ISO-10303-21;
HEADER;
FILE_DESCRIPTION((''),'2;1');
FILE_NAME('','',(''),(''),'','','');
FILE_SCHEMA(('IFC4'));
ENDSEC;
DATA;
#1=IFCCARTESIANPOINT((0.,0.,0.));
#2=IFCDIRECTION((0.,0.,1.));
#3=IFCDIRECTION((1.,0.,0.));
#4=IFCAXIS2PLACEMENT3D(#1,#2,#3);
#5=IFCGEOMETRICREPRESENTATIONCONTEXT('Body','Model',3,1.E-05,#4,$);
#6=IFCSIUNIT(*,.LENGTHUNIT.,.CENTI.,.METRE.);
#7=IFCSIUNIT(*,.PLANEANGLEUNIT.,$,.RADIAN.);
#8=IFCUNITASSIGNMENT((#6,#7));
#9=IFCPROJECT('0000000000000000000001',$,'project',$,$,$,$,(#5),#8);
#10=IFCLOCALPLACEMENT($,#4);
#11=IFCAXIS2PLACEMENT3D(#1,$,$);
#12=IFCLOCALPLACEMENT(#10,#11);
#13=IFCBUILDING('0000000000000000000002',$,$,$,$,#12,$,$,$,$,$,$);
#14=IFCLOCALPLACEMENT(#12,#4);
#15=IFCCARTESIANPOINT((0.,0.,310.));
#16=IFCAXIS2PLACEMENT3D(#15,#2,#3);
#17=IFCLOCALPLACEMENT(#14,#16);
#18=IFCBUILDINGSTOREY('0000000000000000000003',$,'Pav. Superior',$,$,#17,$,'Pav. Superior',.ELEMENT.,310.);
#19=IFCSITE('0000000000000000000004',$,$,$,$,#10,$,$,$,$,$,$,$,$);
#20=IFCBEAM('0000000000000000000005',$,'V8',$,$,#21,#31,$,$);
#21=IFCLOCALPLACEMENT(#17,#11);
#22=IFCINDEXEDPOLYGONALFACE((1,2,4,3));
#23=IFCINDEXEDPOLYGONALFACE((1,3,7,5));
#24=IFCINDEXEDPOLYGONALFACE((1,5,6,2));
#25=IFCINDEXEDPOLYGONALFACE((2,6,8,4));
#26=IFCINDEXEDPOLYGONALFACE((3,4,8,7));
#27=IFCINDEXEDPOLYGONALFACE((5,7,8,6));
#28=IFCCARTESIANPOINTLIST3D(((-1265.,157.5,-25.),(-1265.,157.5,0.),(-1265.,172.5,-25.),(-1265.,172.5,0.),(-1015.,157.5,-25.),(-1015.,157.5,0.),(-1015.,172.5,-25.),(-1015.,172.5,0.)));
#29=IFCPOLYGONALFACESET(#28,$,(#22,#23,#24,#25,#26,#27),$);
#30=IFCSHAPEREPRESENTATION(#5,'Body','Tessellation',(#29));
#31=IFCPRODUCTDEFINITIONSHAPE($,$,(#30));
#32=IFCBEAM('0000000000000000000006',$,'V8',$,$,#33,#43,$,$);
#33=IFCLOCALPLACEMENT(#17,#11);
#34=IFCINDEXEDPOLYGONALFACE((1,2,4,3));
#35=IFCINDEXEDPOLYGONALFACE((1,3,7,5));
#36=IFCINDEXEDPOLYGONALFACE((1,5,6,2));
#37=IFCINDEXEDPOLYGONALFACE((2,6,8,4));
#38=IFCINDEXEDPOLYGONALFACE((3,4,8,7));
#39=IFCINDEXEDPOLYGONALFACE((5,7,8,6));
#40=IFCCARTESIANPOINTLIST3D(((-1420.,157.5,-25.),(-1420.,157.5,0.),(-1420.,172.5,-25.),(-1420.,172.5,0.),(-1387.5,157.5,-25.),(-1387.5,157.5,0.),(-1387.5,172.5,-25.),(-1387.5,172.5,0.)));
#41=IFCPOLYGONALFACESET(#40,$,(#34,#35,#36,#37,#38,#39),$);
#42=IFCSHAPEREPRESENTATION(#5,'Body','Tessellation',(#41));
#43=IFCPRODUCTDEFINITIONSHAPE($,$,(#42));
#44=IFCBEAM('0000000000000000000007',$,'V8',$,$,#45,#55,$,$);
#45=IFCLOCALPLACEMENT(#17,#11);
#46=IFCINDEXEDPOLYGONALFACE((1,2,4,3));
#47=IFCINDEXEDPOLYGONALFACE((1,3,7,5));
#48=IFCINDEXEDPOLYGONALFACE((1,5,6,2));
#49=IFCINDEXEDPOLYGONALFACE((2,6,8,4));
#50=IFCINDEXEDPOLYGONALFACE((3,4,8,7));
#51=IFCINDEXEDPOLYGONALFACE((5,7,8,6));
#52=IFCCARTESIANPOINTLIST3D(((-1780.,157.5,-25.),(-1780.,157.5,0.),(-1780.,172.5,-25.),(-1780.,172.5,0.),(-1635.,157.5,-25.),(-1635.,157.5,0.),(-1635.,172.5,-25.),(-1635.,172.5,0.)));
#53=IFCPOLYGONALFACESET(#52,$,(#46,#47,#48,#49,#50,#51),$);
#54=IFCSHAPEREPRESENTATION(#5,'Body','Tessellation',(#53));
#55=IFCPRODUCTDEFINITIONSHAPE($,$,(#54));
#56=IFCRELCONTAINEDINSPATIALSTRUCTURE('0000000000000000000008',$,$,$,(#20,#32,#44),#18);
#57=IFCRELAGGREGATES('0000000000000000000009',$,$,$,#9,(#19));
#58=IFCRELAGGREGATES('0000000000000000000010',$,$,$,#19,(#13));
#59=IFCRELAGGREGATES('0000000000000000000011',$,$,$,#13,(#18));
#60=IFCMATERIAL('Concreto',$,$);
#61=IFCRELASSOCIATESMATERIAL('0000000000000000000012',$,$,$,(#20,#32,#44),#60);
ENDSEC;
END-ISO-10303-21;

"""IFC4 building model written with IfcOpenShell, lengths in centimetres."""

from ifc_helpers import new_model, si_unit, frame, origin, origin_with_axes, origin_2d_with_axis, place, context, project, spatial, rectangle, extrude, material, element, save


model = new_model("IFC4")

# Units and contexts
model_context = context("Model", 3, precision=1e-05, world=origin_with_axes(), identifier="Body")
ifc_project = project(units=[si_unit("LENGTHUNIT", "METRE", prefix="CENTI"), si_unit("PLANEANGLEUNIT", "RADIAN")], contexts=[model_context])

# Site, building, storey
site_placement = place(None, origin_with_axes())
site = spatial("IfcSite", under=ifc_project, at=site_placement)
building_placement = place(site_placement, origin())
building = spatial("IfcBuilding", under=site, at=building_placement)
placement = place(building_placement, origin_with_axes())
storey_placement = place(placement, frame((0.0, 0.0, 310.0), z_axis=(0.0, 0.0, 1.0), x_axis=(1.0, 0.0, 0.0)))
storey = spatial("IfcBuildingStorey", under=building, at=storey_placement, Name="Pav. Superior", LongName="Pav. Superior", CompositionType="ELEMENT", Elevation=310.0)

# Shared definitions
ifc_material = material(Name="Concreto")

# Beams
beam_1_placement = place(storey_placement, frame((-1140.0, 165.0, 0.0), z_axis=(0.0, 0.0, 1.0), x_axis=(1.0, 0.0, 0.0)))
element("IfcBeam", 1, at=beam_1_placement, inside=storey, material=ifc_material, Name="V8", context=model_context, shape_type="SolidModel", body=[
    extrude(rectangle(XDim=15.0, YDim=25.0, at=origin_2d_with_axis()), frame((-125.0, 0.0, -12.5), z_axis=(1.0, 0.0, 0.0), x_axis=(0.0, -1.0, 0.0)), (0.0, 0.0, 1.0), 250.0),
])
beam_2_placement = place(storey_placement, frame((-1403.75, 165.0, 0.0), z_axis=(0.0, 0.0, 1.0), x_axis=(1.0, 0.0, 0.0)))
element("IfcBeam", 2, at=beam_2_placement, inside=storey, material=ifc_material, Name="V8", context=model_context, shape_type="SolidModel", body=[
    extrude(rectangle(XDim=15.0, YDim=25.0, at=origin_2d_with_axis()), frame((-16.25, 0.0, -12.5), z_axis=(1.0, 0.0, 0.0), x_axis=(0.0, -1.0, 0.0)), (0.0, 0.0, 1.0), 32.5),
])
beam_3_placement = place(storey_placement, frame((-1707.5, 165.0, 0.0), z_axis=(0.0, 0.0, 1.0), x_axis=(1.0, 0.0, 0.0)))
element("IfcBeam", 3, at=beam_3_placement, inside=storey, material=ifc_material, Name="V8", context=model_context, shape_type="SolidModel", body=[
    extrude(rectangle(XDim=15.0, YDim=25.0, at=origin_2d_with_axis()), frame((-72.5, 0.0, -12.5), z_axis=(1.0, 0.0, 0.0), x_axis=(0.0, -1.0, 0.0)), (0.0, 0.0, 1.0), 145.0),
])

save(model, "model.ifc")
